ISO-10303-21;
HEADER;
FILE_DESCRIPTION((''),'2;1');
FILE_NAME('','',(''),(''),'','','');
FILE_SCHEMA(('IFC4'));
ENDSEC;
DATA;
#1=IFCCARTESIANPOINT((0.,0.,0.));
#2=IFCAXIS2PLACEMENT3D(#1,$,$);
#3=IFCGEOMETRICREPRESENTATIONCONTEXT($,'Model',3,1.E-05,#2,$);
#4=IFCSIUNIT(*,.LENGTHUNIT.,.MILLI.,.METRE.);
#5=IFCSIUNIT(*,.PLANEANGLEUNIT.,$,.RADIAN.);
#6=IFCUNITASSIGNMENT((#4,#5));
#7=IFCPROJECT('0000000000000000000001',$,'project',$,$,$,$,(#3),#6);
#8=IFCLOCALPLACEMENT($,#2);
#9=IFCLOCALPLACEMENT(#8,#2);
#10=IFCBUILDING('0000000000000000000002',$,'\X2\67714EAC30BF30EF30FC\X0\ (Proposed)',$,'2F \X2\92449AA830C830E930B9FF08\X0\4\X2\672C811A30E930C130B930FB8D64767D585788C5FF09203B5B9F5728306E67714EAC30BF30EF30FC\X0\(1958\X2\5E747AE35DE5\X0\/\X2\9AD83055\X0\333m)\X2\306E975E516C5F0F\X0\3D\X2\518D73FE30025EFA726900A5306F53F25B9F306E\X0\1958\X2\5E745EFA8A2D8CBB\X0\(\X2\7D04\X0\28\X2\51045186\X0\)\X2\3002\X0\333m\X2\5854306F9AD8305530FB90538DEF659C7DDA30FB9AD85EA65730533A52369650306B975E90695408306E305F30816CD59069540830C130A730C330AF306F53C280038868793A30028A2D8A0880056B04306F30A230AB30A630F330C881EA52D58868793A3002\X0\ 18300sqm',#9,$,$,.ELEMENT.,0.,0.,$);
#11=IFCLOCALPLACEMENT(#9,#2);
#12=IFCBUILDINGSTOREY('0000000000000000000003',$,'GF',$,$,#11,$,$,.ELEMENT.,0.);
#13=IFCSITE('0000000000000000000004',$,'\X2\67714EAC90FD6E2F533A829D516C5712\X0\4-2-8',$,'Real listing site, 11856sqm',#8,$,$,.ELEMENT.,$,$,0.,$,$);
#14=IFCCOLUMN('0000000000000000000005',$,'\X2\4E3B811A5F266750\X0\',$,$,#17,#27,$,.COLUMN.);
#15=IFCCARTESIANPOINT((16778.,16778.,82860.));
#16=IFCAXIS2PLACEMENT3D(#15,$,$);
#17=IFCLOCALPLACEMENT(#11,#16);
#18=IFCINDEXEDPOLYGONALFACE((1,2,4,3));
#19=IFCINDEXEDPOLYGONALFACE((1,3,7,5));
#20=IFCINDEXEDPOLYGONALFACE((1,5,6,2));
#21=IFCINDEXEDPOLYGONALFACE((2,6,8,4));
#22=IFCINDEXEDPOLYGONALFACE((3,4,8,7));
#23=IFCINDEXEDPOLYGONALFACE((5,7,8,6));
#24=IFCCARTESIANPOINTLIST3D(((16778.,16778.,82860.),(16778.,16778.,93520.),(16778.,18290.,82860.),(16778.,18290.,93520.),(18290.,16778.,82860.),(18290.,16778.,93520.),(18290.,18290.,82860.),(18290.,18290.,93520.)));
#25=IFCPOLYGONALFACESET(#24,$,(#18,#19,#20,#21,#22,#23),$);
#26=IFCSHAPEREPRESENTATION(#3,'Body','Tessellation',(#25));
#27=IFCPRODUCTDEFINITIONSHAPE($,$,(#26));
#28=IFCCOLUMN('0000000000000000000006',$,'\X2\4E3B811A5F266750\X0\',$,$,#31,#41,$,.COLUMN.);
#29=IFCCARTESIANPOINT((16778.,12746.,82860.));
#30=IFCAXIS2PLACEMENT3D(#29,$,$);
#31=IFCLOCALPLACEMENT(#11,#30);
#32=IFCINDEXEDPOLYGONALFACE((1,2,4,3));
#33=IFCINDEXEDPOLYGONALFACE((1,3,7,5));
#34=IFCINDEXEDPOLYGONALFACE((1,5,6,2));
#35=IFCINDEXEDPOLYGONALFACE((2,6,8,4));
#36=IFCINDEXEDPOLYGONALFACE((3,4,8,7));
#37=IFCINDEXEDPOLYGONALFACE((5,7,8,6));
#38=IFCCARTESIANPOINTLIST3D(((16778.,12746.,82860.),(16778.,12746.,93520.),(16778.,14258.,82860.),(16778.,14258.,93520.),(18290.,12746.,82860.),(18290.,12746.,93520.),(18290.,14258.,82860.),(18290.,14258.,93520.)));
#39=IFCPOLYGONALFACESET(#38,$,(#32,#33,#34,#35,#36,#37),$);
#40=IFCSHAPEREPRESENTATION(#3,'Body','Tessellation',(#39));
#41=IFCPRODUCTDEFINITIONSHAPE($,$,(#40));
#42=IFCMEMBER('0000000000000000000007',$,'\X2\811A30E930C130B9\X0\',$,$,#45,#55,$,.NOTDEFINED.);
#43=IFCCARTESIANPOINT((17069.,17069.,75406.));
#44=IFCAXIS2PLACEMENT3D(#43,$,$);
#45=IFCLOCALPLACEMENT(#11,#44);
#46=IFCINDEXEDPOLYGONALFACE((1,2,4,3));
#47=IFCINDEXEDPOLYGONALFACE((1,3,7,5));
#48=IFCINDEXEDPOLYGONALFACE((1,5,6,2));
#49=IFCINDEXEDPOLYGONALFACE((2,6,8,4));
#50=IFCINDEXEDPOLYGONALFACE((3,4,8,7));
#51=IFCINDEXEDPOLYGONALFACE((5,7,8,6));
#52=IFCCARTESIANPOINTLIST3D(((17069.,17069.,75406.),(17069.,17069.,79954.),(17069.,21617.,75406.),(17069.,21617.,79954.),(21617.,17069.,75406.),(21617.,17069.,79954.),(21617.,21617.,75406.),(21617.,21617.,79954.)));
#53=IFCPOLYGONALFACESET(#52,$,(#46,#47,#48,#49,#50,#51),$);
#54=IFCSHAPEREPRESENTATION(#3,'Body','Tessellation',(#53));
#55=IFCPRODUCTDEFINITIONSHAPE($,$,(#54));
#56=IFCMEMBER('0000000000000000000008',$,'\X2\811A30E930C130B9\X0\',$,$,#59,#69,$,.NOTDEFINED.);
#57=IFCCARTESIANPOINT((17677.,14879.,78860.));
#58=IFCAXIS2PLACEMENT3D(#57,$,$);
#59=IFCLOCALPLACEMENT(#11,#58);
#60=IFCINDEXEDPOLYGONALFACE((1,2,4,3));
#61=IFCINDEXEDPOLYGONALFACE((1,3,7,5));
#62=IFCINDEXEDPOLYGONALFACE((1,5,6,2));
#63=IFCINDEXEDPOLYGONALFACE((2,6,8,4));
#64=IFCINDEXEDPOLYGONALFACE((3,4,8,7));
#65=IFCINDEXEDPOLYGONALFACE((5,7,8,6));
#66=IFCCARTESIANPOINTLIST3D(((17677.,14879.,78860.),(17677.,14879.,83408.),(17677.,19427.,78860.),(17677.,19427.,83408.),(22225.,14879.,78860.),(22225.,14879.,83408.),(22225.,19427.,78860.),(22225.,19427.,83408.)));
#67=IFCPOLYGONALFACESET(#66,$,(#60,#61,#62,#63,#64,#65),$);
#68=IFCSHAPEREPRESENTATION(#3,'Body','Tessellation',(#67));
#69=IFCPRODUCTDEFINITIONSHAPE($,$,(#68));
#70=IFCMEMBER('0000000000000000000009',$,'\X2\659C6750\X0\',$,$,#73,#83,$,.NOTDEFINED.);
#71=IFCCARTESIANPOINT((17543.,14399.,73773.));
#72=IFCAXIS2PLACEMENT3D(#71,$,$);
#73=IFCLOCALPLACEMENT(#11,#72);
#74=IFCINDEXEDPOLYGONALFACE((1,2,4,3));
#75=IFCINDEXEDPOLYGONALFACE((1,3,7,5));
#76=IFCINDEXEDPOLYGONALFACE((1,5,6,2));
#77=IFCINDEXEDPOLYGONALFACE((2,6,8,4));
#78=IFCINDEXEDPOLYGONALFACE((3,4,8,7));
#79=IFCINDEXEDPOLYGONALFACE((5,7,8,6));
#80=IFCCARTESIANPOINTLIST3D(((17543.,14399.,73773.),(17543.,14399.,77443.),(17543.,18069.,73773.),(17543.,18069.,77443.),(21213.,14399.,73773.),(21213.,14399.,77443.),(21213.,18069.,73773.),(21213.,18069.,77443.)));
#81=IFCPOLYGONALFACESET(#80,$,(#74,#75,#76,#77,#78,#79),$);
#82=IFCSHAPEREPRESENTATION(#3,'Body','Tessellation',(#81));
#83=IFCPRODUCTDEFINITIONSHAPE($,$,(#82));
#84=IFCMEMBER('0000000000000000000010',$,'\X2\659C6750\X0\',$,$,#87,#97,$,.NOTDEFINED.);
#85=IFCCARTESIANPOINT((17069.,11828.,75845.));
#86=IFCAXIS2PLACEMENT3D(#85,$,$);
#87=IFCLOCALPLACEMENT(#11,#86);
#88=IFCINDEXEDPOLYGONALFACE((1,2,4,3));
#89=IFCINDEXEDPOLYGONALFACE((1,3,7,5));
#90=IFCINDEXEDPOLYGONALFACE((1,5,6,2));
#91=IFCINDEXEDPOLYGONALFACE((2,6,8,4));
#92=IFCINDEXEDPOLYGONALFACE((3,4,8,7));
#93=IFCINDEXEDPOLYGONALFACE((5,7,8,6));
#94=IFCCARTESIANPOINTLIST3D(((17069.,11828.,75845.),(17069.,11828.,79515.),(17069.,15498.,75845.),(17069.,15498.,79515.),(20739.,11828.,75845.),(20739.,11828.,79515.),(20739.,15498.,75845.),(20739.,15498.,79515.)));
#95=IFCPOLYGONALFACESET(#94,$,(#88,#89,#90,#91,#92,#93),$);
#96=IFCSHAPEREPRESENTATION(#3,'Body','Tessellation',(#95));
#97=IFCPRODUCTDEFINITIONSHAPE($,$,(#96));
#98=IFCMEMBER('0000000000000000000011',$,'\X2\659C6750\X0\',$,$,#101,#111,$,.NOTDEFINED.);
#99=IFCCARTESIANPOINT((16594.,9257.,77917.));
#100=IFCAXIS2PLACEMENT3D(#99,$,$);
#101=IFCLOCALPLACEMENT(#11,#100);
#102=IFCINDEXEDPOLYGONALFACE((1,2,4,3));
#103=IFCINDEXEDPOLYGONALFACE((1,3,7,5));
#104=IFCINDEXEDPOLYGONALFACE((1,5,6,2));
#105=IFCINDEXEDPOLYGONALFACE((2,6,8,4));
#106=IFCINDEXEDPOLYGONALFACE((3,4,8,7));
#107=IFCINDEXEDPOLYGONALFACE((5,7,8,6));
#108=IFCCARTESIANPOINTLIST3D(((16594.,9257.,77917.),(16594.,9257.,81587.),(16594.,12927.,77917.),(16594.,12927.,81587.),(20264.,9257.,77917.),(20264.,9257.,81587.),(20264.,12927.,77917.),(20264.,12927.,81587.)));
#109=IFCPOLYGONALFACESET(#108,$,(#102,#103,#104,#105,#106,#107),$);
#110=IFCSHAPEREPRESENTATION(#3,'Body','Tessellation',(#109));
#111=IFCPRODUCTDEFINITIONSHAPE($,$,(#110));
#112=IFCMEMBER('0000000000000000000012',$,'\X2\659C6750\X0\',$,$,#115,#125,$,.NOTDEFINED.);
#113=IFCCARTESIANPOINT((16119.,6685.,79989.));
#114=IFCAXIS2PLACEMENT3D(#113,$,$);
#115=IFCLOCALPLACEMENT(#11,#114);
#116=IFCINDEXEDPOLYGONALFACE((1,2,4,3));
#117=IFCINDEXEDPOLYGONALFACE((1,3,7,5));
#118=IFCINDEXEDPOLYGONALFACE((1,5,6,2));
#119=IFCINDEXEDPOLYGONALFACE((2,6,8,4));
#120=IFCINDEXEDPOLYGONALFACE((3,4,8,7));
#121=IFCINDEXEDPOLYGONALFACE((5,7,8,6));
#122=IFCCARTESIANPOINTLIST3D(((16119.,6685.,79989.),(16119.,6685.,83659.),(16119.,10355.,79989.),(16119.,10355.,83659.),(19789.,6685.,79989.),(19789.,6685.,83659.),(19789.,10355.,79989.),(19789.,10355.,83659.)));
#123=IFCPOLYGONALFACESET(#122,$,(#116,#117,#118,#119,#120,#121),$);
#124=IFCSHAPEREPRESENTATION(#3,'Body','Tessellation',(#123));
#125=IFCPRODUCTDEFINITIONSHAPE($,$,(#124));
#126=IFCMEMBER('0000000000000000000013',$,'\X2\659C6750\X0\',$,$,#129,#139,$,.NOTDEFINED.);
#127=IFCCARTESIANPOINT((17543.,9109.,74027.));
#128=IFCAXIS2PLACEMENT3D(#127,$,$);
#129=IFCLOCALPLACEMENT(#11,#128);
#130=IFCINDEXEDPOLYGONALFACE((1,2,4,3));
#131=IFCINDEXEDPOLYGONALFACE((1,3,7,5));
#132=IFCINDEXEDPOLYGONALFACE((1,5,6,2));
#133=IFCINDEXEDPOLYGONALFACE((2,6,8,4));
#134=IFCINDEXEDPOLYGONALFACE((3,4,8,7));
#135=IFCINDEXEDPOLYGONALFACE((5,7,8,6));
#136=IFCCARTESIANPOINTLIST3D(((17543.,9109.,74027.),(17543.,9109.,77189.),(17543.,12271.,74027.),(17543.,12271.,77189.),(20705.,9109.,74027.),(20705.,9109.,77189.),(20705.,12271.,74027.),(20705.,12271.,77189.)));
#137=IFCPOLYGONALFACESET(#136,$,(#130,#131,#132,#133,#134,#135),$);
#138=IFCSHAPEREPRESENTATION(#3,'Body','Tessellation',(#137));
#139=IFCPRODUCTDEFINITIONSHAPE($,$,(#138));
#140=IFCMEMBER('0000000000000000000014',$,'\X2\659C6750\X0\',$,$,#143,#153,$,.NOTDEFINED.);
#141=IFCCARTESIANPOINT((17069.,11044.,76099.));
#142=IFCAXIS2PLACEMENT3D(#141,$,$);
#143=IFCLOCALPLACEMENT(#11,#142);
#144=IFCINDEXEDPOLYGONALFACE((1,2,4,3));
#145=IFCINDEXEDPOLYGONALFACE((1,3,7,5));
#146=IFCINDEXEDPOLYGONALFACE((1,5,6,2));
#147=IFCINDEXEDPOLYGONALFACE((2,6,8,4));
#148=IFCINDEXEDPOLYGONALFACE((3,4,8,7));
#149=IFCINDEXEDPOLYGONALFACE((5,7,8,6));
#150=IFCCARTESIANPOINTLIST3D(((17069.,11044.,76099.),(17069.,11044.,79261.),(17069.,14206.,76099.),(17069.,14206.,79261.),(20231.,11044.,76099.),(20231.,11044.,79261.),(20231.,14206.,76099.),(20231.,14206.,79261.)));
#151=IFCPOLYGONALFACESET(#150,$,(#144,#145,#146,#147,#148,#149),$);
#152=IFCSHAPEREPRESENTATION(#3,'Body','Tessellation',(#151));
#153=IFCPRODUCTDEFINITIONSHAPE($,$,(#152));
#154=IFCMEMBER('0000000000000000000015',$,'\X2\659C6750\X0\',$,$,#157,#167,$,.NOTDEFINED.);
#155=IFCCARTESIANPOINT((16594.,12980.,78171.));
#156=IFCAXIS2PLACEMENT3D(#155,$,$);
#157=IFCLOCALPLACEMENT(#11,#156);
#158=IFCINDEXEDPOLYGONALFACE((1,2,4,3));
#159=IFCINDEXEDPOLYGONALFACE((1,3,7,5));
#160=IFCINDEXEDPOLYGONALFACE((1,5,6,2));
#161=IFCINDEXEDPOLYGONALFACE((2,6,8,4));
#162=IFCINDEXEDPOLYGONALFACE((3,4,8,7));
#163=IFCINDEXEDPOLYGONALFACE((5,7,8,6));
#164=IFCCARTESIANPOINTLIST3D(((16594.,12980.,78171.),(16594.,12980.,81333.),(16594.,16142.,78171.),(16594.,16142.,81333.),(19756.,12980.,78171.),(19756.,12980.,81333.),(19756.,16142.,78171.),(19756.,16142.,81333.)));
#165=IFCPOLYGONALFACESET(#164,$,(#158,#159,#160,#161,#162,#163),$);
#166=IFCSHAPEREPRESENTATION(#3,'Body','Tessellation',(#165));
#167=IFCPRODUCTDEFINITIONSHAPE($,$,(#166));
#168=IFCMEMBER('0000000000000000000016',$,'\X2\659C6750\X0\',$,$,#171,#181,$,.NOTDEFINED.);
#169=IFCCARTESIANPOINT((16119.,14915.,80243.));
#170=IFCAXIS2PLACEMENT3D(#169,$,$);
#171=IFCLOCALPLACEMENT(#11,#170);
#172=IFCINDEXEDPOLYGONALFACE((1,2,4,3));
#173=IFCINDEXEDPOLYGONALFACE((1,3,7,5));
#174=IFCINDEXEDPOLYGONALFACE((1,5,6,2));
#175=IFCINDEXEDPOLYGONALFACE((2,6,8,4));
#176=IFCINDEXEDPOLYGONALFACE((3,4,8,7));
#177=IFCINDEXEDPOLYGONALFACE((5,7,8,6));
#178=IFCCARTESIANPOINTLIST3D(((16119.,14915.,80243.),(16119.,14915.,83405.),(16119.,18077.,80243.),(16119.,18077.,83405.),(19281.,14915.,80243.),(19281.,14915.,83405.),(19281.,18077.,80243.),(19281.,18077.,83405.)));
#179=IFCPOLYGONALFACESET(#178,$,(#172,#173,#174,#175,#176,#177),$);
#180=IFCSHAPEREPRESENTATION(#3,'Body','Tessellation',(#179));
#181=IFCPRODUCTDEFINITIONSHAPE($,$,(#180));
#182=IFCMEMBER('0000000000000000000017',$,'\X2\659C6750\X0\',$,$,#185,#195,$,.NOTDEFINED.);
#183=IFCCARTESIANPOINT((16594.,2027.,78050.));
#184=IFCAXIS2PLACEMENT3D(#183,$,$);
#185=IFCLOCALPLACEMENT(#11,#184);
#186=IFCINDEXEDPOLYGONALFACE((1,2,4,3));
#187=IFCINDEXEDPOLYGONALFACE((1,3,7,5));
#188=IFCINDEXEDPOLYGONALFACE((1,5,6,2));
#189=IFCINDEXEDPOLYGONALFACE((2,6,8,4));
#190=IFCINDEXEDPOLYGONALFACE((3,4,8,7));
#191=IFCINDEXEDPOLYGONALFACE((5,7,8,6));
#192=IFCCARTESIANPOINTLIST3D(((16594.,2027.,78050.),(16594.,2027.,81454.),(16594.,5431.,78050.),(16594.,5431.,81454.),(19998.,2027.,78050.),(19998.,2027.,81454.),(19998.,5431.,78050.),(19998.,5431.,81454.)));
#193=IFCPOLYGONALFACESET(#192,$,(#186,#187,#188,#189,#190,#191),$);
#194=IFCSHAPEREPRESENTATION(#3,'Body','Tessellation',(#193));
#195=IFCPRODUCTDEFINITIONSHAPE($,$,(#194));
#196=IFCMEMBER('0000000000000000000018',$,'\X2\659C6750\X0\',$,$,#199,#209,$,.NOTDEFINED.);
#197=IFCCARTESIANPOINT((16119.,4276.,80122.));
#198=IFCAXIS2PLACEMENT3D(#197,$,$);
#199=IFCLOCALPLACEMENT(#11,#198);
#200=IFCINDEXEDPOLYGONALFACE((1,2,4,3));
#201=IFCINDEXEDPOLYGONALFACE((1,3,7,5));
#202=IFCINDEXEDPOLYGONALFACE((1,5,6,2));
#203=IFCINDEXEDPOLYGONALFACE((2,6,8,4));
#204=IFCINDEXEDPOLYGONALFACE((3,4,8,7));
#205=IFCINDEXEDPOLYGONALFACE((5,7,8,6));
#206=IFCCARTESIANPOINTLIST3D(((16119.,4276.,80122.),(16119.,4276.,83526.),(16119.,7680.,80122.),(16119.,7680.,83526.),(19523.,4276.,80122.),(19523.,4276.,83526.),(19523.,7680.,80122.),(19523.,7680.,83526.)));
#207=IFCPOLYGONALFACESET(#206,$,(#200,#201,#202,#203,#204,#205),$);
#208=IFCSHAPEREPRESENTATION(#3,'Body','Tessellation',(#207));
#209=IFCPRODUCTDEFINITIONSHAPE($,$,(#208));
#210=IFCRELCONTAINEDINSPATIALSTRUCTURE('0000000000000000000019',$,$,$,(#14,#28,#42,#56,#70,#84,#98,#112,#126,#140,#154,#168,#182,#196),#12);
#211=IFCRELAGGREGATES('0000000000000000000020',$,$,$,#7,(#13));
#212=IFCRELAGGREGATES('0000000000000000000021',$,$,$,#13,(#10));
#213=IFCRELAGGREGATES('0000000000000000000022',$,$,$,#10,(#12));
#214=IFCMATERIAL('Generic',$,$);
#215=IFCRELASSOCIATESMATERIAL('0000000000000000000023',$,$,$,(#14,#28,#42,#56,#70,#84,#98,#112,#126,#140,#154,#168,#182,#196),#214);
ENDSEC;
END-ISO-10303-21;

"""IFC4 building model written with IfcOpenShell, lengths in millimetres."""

from ifc_helpers import new_model, si_unit, frame, frame_2d, origin, place, context, project, spatial, rectangle, extrude, material, element, save


model = new_model("IFC4")

# Units and contexts
model_context = context("Model", 3, precision=1e-05, world=origin())
ifc_project = project(units=[si_unit("LENGTHUNIT", "METRE", prefix="MILLI"), si_unit("PLANEANGLEUNIT", "RADIAN")], contexts=[model_context])

# Site, building, storey
site_placement = place(None, origin())
site = spatial("IfcSite", under=ifc_project, at=site_placement, Name="東京都港区芝公園4-2-8", ObjectType="Real listing site, 11856sqm", CompositionType="ELEMENT", RefElevation=0.0)
building_placement = place(site_placement, origin())
building = spatial("IfcBuilding", under=site, at=building_placement, Name="東京タワー (Proposed)", ObjectType="2F 鉄骨トラス（4本脚ラチス・赤白塗装）※実在の東京タワー(1958年竣工/高さ333m)の非公式3D再現。建物¥は史実の1958年建設費(約28億円)。333m塔は高さ・道路斜線・高度地区制限に非適合のため法適合チェックは参考表示。設計者欄はアカウント自動表示。 18300sqm", CompositionType="ELEMENT", ElevationOfRefHeight=0.0, ElevationOfTerrain=0.0)
storey_placement = place(building_placement, origin())
storey = spatial("IfcBuildingStorey", under=building, at=storey_placement, Name="GF", CompositionType="ELEMENT", Elevation=0.0)

# Columns
ifc_material = material(Name="Generic")
column_1_placement = place(storey_placement, frame((16778.0, 16778.0, 82860.0)))
element("IfcColumn", 1, at=column_1_placement, inside=storey, material=ifc_material, Name="主脚弦材", PredefinedType="COLUMN", context=model_context, shape_type="SweptSolid", body=[
    extrude(rectangle(XDim=1512.0, YDim=1512.0, at=frame_2d((756.0, 756.0))), frame((16778.0, 16778.0, 82860.0)), (0.0, 0.0, 1.0), 10660.0),
])
column_2_placement = place(storey_placement, frame((16778.0, 12746.0, 82860.0)))
element("IfcColumn", 2, at=column_2_placement, inside=storey, material=ifc_material, Name="主脚弦材", PredefinedType="COLUMN", context=model_context, shape_type="SweptSolid", body=[
    extrude(rectangle(XDim=1512.0, YDim=1512.0, at=frame_2d((756.0, 756.0))), frame((16778.0, 12746.0, 82860.0)), (0.0, 0.0, 1.0), 10660.0),
])

# Members
member_1_placement = place(storey_placement, frame((17069.0, 17069.0, 75406.0)))
element("IfcMember", 3, at=member_1_placement, inside=storey, material=ifc_material, Name="脚ラチス", PredefinedType="NOTDEFINED", context=model_context, shape_type="SweptSolid", body=[
    extrude(rectangle(XDim=4548.0, YDim=4548.0, at=frame_2d((2274.0, 2274.0))), frame((17069.0, 17069.0, 75406.0)), (0.0, 0.0, 1.0), 4548.0),
])
member_2_placement = place(storey_placement, frame((17677.0, 14879.0, 78860.0)))
element("IfcMember", 4, at=member_2_placement, inside=storey, material=ifc_material, Name="脚ラチス", PredefinedType="NOTDEFINED", context=model_context, shape_type="SweptSolid", body=[
    extrude(rectangle(XDim=4548.0, YDim=4548.0, at=frame_2d((2274.0, 2274.0))), frame((17677.0, 14879.0, 78860.0)), (0.0, 0.0, 1.0), 4548.0),
])
member_3_placement = place(storey_placement, frame((17543.0, 14399.0, 73773.0)))
element("IfcMember", 5, at=member_3_placement, inside=storey, material=ifc_material, Name="斜材", PredefinedType="NOTDEFINED", context=model_context, shape_type="SweptSolid", body=[
    extrude(rectangle(XDim=3670.0, YDim=3670.0, at=frame_2d((1835.0, 1835.0))), frame((17543.0, 14399.0, 73773.0)), (0.0, 0.0, 1.0), 3670.0),
])
member_4_placement = place(storey_placement, frame((17069.0, 11828.0, 75845.0)))
element("IfcMember", 6, at=member_4_placement, inside=storey, material=ifc_material, Name="斜材", PredefinedType="NOTDEFINED", context=model_context, shape_type="SweptSolid", body=[
    extrude(rectangle(XDim=3670.0, YDim=3670.0, at=frame_2d((1835.0, 1835.0))), frame((17069.0, 11828.0, 75845.0)), (0.0, 0.0, 1.0), 3670.0),
])
member_5_placement = place(storey_placement, frame((16594.0, 9257.0, 77917.0)))
element("IfcMember", 7, at=member_5_placement, inside=storey, material=ifc_material, Name="斜材", PredefinedType="NOTDEFINED", context=model_context, shape_type="SweptSolid", body=[
    extrude(rectangle(XDim=3670.0, YDim=3670.0, at=frame_2d((1835.0, 1835.0))), frame((16594.0, 9257.0, 77917.0)), (0.0, 0.0, 1.0), 3670.0),
])
member_6_placement = place(storey_placement, frame((16119.0, 6685.0, 79989.0)))
element("IfcMember", 8, at=member_6_placement, inside=storey, material=ifc_material, Name="斜材", PredefinedType="NOTDEFINED", context=model_context, shape_type="SweptSolid", body=[
    extrude(rectangle(XDim=3670.0, YDim=3670.0, at=frame_2d((1835.0, 1835.0))), frame((16119.0, 6685.0, 79989.0)), (0.0, 0.0, 1.0), 3670.0),
])
member_7_placement = place(storey_placement, frame((17543.0, 9109.0, 74027.0)))
element("IfcMember", 9, at=member_7_placement, inside=storey, material=ifc_material, Name="斜材", PredefinedType="NOTDEFINED", context=model_context, shape_type="SweptSolid", body=[
    extrude(rectangle(XDim=3162.0, YDim=3162.0, at=frame_2d((1581.0, 1581.0))), frame((17543.0, 9109.0, 74027.0)), (0.0, 0.0, 1.0), 3162.0),
])
member_8_placement = place(storey_placement, frame((17069.0, 11044.0, 76099.0)))
element("IfcMember", 10, at=member_8_placement, inside=storey, material=ifc_material, Name="斜材", PredefinedType="NOTDEFINED", context=model_context, shape_type="SweptSolid", body=[
    extrude(rectangle(XDim=3162.0, YDim=3162.0, at=frame_2d((1581.0, 1581.0))), frame((17069.0, 11044.0, 76099.0)), (0.0, 0.0, 1.0), 3162.0),
])
member_9_placement = place(storey_placement, frame((16594.0, 12980.0, 78171.0)))
element("IfcMember", 11, at=member_9_placement, inside=storey, material=ifc_material, Name="斜材", PredefinedType="NOTDEFINED", context=model_context, shape_type="SweptSolid", body=[
    extrude(rectangle(XDim=3162.0, YDim=3162.0, at=frame_2d((1581.0, 1581.0))), frame((16594.0, 12980.0, 78171.0)), (0.0, 0.0, 1.0), 3162.0),
])
member_10_placement = place(storey_placement, frame((16119.0, 14915.0, 80243.0)))
element("IfcMember", 12, at=member_10_placement, inside=storey, material=ifc_material, Name="斜材", PredefinedType="NOTDEFINED", context=model_context, shape_type="SweptSolid", body=[
    extrude(rectangle(XDim=3162.0, YDim=3162.0, at=frame_2d((1581.0, 1581.0))), frame((16119.0, 14915.0, 80243.0)), (0.0, 0.0, 1.0), 3162.0),
])
member_11_placement = place(storey_placement, frame((16594.0, 2027.0, 78050.0)))
element("IfcMember", 13, at=member_11_placement, inside=storey, material=ifc_material, Name="斜材", PredefinedType="NOTDEFINED", context=model_context, shape_type="SweptSolid", body=[
    extrude(rectangle(XDim=3404.0, YDim=3404.0, at=frame_2d((1702.0, 1702.0))), frame((16594.0, 2027.0, 78050.0)), (0.0, 0.0, 1.0), 3404.0),
])
member_12_placement = place(storey_placement, frame((16119.0, 4276.0, 80122.0)))
element("IfcMember", 14, at=member_12_placement, inside=storey, material=ifc_material, Name="斜材", PredefinedType="NOTDEFINED", context=model_context, shape_type="SweptSolid", body=[
    extrude(rectangle(XDim=3404.0, YDim=3404.0, at=frame_2d((1702.0, 1702.0))), frame((16119.0, 4276.0, 80122.0)), (0.0, 0.0, 1.0), 3404.0),
])

save(model, "model.ifc")
